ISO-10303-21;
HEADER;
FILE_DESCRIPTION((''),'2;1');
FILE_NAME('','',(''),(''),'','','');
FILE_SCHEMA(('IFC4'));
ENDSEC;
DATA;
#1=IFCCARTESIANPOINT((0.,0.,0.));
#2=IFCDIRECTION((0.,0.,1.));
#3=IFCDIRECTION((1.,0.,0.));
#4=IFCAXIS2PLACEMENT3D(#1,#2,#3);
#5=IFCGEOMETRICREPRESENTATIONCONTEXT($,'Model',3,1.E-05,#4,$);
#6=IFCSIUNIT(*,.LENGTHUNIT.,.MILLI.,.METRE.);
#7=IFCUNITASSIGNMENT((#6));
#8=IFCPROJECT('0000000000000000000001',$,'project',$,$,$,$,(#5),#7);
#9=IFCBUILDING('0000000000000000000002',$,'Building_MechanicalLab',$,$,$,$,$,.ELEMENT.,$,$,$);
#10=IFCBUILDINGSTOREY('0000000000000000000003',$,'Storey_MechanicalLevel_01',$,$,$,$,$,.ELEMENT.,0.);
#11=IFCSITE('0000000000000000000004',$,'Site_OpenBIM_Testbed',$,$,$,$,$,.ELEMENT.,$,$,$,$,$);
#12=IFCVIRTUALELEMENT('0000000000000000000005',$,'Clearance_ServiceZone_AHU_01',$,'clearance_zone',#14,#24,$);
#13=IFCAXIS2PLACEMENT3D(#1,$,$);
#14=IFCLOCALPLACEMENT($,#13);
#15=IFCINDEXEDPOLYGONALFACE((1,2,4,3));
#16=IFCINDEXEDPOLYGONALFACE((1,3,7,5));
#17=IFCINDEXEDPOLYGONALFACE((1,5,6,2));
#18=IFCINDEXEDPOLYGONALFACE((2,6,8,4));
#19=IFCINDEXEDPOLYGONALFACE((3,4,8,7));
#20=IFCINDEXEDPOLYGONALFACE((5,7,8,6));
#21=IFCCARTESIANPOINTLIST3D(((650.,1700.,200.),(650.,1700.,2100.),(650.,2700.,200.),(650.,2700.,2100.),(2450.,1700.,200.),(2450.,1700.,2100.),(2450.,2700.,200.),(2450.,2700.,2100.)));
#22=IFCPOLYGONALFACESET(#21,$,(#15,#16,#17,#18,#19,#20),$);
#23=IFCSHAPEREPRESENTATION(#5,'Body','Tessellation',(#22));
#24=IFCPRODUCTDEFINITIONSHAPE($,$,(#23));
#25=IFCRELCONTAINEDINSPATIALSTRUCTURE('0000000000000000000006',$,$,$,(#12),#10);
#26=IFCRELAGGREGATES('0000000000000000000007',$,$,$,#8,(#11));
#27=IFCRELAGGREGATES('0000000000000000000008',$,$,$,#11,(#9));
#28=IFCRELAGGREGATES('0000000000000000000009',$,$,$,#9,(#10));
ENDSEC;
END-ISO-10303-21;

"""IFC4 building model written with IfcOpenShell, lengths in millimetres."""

from ifc_helpers import new_model, si_unit, frame, origin_with_axes, place, context, project, spatial, rectangle, extrude, element, save


model = new_model("IFC4")

# Units and contexts
model_context = context("Model", 3, precision=1e-05, world=origin_with_axes())
ifc_project = project(units=[si_unit("LENGTHUNIT", "METRE", prefix="MILLI")], contexts=[model_context])

# Site, building, storey
site = spatial("IfcSite", under=ifc_project, Name="Site_OpenBIM_Testbed", CompositionType="ELEMENT")
building = spatial("IfcBuilding", under=site, Name="Building_MechanicalLab", CompositionType="ELEMENT")
storey = spatial("IfcBuildingStorey", under=building, Name="Storey_MechanicalLevel_01", CompositionType="ELEMENT", Elevation=0.0)

# Virtual element
virtual_element_placement = place(None, frame((650.0, 1700.0, 200.0), z_axis=(0.0, 0.0, 1.0), x_axis=(1.0, 0.0, 0.0)))
element("IfcVirtualElement", 1, at=virtual_element_placement, inside=storey, Name="Clearance_ServiceZone_AHU_01", ObjectType="clearance_zone", context=model_context, shape_type="SweptSolid", body=[
    extrude(rectangle(XDim=1800.0, YDim=1000.0), frame((900.0, 500.0, 0.0), z_axis=(0.0, 0.0, 1.0), x_axis=(1.0, 0.0, 0.0)), (0.0, 0.0, 1.0), 1900.0),
])

save(model, "model.ifc")
